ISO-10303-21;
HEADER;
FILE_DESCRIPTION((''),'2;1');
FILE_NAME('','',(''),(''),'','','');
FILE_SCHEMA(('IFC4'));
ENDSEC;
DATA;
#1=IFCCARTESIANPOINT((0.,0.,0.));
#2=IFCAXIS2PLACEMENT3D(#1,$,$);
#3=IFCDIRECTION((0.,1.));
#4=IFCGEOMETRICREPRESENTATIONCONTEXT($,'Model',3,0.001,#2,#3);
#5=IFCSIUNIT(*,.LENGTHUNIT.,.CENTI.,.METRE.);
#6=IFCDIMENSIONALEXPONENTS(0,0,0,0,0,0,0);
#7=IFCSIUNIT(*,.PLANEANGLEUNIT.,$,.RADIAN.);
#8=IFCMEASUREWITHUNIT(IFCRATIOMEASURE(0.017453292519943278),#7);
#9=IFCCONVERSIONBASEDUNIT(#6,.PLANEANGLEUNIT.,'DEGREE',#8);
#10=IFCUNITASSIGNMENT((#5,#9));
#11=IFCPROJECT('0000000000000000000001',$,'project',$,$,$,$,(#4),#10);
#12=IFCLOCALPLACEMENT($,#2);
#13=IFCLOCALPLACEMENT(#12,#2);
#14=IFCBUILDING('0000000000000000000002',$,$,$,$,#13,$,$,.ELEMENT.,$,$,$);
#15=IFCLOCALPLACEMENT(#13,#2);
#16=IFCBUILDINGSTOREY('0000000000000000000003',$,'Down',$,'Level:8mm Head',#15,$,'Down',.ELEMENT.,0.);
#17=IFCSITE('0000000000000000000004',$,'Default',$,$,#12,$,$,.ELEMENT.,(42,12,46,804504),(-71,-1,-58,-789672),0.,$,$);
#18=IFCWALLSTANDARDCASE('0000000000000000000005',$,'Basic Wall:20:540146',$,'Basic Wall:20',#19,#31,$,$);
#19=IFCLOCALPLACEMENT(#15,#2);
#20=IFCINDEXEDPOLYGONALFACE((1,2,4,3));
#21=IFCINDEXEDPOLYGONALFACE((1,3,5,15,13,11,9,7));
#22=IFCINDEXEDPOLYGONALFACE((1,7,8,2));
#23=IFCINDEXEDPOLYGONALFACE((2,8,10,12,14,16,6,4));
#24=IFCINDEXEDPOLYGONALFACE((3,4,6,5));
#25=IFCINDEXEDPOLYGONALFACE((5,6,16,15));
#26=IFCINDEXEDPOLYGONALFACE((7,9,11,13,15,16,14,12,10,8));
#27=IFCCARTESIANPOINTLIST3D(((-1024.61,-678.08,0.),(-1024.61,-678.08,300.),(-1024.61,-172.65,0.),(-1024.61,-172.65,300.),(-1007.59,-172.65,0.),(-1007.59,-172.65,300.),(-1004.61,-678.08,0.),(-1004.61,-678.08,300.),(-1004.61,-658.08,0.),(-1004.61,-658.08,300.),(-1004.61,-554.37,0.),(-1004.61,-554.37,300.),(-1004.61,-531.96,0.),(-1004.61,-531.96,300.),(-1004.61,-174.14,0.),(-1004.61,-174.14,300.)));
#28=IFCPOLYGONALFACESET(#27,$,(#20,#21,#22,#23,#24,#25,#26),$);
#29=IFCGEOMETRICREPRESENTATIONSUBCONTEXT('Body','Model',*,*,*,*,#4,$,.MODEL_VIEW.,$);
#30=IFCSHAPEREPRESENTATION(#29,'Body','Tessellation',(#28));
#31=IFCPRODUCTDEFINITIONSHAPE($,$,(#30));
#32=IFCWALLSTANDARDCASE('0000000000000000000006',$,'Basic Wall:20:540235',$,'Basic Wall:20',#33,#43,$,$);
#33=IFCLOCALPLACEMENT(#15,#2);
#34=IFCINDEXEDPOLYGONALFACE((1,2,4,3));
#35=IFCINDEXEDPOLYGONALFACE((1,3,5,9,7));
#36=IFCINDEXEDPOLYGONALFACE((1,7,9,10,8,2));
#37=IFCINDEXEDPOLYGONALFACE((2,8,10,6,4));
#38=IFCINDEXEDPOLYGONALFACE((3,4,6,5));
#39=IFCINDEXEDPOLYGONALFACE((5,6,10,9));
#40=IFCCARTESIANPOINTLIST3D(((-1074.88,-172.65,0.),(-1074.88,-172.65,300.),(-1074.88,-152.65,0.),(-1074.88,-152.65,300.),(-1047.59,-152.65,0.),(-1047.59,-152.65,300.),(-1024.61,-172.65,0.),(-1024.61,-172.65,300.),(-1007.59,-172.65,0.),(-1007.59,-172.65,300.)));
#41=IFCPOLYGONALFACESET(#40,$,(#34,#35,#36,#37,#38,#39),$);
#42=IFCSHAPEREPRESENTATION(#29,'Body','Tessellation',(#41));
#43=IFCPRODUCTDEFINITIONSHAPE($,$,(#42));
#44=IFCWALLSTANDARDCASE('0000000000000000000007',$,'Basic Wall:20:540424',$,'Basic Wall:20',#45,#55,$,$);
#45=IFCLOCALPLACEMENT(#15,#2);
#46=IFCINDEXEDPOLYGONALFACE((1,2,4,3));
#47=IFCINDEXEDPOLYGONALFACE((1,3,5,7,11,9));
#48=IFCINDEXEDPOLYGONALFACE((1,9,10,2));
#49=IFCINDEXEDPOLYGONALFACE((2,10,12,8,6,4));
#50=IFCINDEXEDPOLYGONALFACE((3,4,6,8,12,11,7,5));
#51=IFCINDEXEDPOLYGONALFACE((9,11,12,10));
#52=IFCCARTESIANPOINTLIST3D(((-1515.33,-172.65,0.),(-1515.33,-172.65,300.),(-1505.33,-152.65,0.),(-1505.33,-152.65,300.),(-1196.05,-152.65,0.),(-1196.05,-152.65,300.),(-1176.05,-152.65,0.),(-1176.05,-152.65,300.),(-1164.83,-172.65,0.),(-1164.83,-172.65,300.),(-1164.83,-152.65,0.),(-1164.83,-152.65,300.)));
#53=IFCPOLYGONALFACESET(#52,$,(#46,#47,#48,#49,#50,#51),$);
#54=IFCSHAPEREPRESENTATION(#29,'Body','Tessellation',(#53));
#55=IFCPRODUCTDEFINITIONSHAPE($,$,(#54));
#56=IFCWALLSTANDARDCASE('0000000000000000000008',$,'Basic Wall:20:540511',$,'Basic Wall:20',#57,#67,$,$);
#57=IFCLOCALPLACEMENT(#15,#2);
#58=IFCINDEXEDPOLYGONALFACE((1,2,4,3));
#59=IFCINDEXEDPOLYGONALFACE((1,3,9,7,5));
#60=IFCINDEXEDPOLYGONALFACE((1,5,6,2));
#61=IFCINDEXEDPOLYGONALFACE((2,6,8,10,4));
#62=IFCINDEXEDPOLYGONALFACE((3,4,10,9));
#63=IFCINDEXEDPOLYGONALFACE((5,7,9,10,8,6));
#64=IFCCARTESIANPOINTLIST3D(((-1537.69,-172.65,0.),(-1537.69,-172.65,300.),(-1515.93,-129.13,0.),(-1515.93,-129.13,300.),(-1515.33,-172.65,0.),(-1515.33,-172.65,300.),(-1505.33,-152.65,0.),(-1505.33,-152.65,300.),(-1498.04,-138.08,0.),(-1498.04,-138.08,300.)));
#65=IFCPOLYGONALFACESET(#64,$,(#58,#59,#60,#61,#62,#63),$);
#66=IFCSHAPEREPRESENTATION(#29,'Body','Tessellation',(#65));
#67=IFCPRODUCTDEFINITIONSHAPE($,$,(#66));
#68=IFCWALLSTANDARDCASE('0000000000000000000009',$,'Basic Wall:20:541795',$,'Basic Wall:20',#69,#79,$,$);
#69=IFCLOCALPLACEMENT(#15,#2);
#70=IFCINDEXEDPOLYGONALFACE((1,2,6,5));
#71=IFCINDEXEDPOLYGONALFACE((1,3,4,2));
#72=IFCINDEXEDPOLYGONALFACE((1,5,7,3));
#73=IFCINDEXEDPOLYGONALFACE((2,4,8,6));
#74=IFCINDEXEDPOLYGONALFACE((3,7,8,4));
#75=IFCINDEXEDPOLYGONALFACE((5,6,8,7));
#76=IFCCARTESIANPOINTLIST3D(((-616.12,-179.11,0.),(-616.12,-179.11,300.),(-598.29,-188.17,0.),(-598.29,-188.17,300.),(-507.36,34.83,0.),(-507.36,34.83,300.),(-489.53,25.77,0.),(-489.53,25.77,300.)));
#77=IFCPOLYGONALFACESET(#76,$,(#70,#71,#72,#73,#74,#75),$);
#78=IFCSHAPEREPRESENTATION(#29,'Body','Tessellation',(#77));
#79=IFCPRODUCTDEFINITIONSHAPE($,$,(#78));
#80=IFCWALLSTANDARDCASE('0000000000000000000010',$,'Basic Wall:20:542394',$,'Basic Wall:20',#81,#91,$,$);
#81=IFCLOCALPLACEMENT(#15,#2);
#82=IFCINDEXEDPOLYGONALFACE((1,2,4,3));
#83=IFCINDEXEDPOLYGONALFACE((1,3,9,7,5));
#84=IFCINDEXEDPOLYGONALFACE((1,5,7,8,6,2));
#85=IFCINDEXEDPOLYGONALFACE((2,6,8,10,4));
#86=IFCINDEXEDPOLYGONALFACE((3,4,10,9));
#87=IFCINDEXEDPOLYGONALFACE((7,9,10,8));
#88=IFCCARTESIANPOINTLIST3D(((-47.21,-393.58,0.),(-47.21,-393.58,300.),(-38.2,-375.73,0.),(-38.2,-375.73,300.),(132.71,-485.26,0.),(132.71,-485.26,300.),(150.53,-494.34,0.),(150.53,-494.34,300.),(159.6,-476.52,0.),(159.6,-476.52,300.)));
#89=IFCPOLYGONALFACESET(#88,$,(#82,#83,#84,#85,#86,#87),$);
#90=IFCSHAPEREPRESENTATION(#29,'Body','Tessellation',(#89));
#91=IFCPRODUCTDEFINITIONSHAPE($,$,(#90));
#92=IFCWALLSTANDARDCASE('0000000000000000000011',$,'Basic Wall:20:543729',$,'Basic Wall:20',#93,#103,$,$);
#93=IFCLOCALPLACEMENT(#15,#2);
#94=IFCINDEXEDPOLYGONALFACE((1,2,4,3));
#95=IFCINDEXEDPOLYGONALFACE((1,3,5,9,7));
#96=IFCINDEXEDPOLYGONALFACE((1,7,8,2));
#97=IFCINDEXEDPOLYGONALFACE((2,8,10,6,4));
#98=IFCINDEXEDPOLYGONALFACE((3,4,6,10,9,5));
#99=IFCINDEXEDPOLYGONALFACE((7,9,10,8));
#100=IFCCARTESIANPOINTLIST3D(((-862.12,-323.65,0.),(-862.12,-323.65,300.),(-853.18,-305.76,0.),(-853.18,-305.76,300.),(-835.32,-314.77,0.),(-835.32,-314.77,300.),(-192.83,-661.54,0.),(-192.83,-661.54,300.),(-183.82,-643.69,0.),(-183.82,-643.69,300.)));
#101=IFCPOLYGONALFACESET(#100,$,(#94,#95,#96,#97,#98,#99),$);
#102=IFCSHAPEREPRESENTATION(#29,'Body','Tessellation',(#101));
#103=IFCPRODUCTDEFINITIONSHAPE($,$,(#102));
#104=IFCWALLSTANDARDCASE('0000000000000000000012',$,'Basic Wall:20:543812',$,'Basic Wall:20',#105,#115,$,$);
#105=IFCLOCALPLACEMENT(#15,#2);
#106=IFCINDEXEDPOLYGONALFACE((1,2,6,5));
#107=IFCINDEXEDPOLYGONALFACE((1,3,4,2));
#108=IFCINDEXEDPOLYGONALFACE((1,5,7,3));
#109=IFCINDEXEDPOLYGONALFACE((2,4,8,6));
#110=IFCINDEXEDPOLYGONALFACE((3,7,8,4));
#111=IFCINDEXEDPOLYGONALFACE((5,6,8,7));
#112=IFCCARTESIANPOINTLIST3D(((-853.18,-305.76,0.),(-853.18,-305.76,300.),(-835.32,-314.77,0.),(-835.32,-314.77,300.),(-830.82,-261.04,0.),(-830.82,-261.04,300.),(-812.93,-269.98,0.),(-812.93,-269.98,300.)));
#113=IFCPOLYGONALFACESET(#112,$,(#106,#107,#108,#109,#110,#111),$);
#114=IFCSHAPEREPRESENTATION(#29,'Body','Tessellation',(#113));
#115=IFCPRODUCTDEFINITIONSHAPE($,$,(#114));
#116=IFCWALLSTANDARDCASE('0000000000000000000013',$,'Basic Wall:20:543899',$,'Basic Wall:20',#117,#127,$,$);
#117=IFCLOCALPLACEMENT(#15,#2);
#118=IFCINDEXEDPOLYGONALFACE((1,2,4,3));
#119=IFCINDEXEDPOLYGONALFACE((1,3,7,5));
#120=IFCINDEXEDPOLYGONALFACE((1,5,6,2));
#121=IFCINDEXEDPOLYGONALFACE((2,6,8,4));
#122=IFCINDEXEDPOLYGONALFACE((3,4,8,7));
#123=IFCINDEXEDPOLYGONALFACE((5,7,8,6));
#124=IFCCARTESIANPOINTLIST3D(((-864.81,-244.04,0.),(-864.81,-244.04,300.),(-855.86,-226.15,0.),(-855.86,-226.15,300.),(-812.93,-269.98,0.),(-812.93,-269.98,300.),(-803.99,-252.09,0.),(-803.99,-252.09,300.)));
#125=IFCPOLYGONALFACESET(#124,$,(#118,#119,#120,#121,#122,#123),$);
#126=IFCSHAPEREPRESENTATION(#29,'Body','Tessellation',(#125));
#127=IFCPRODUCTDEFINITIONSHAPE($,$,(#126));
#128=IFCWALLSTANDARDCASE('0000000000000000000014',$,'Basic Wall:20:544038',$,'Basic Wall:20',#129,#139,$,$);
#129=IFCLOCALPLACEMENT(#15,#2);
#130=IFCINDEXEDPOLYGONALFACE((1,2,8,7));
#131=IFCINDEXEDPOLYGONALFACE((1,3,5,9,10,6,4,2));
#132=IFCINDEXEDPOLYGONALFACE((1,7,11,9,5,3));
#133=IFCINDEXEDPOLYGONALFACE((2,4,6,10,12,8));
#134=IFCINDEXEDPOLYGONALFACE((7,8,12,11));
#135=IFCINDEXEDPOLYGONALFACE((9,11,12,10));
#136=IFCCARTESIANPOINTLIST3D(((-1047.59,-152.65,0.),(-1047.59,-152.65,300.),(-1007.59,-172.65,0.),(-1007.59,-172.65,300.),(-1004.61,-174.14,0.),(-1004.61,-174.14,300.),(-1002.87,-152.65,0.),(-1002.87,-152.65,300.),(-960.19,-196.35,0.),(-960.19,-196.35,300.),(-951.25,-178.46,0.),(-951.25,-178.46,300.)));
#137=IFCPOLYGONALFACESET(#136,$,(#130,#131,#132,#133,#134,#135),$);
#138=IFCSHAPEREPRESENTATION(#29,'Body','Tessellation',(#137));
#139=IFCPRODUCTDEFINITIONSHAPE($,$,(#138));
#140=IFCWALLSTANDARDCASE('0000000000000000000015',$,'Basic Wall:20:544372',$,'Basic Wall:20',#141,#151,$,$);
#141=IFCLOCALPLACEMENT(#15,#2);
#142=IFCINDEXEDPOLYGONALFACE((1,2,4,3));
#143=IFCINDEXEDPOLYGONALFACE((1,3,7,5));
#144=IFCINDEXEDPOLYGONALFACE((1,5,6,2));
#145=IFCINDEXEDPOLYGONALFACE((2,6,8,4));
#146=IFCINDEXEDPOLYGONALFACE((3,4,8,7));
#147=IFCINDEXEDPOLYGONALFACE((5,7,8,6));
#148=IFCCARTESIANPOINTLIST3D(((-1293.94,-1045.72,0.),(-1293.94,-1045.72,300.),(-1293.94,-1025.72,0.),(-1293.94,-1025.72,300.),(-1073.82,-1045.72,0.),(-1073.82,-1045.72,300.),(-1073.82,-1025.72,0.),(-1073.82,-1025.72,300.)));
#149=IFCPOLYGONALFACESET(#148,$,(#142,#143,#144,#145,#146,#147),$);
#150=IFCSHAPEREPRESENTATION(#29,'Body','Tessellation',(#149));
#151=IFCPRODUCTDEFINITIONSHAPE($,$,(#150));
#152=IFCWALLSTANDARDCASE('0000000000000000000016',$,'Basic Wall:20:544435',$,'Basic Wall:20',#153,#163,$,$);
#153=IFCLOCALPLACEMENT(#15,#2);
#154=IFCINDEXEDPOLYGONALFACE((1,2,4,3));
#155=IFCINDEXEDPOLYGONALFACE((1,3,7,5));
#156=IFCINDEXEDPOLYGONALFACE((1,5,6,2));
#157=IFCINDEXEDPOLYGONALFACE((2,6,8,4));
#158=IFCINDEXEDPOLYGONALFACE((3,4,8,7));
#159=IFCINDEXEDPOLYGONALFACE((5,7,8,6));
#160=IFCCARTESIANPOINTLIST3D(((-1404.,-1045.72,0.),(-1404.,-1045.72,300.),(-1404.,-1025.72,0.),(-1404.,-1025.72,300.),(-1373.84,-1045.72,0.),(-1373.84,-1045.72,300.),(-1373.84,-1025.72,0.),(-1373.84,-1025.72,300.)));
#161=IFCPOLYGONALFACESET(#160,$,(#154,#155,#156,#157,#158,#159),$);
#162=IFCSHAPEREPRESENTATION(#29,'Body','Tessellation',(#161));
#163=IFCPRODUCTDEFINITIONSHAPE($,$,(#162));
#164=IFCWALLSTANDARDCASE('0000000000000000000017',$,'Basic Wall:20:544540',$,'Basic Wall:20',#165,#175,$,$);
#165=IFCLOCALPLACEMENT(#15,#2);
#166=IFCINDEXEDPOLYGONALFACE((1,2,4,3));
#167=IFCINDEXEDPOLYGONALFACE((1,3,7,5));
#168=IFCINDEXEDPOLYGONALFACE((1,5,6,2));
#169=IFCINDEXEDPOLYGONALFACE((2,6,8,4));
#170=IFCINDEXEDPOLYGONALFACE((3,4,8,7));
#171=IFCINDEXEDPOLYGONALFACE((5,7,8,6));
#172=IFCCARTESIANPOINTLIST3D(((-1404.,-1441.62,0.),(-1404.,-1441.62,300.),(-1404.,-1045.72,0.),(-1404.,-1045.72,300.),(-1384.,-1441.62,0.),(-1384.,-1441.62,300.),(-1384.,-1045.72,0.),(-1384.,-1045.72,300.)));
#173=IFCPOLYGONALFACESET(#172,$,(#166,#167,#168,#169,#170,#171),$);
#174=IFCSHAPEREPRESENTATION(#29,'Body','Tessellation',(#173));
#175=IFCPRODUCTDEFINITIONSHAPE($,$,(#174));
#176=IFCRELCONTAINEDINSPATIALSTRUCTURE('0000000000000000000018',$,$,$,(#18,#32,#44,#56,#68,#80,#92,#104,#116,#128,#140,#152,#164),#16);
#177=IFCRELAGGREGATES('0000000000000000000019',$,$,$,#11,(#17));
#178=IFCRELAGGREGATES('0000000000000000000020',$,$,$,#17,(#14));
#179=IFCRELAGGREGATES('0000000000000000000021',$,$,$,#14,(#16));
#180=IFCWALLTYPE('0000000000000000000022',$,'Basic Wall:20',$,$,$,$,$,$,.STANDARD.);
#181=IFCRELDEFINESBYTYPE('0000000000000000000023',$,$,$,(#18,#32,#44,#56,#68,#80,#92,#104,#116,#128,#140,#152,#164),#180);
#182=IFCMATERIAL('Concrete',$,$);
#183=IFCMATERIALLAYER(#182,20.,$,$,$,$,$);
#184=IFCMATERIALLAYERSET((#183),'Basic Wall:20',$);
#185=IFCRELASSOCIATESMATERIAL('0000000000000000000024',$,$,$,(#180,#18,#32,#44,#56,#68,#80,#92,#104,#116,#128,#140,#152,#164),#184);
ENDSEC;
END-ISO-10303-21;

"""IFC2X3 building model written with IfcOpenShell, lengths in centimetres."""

from ifc_helpers import new_model, entity, si_unit, converted_unit, direction, frame, frame_2d, origin, place, context, subcontext, project, spatial, polyline, rectangle, outline, extrude, material, layer, layer_set, layer_usage, type_object, element, save


model = new_model("IFC2X3")

# Units and contexts
model_context = context("Model", 3, precision=0.001, world=origin(), true_north=direction((0.0, 1.0)))
body_context = subcontext(model_context, "Body", "Model", "MODEL_VIEW")
ifc_project = project(units=[si_unit("LENGTHUNIT", "METRE", prefix="CENTI"), converted_unit("PLANEANGLEUNIT", "DEGREE", entity("IfcRatioMeasure", 0.017453292519943278), si_unit("PLANEANGLEUNIT", "RADIAN"), dimensions=[0, 0, 0, 0, 0, 0, 0])], contexts=[model_context])

# Site, building, storey
site_placement = place(None, origin())
site = spatial("IfcSite", under=ifc_project, at=site_placement, Name="Default", CompositionType="ELEMENT", RefLatitude=(42, 12, 46, 804504), RefLongitude=(-71, -1, -58, -789672), RefElevation=0.0)
building_placement = place(site_placement, origin())
building = spatial("IfcBuilding", under=site, at=building_placement, CompositionType="ELEMENT")
storey_placement = place(building_placement, origin())
storey = spatial("IfcBuildingStorey", under=building, at=storey_placement, Name="Down", ObjectType="Level:8mm Head", LongName="Down", CompositionType="ELEMENT", Elevation=0.0)

# Walls
ifc_material = material(Name="Concrete")
ifc_layer_1 = layer(ifc_material, 20.0)
ifc_layer_set_1 = layer_set([ifc_layer_1], Name="Basic Wall:20")
ifc_layer_usage_1 = layer_usage(ifc_layer_set_1, "AXIS2", "NEGATIVE", 10.0)
wall_type_1 = type_object("IfcWallType", Name="Basic Wall:20", PredefinedType="STANDARD", material=ifc_layer_set_1)
wall_1_placement = place(storey_placement, frame((-1014.61, -678.08, 0.0), z_axis=(0.0, 0.0, 1.0), x_axis=(0.0, 1.0, 0.0)))
element("IfcWallStandardCase", 1, at=wall_1_placement, inside=storey, type_object=wall_type_1, material=ifc_layer_usage_1, Name="Basic Wall:20:540146", ObjectType="Basic Wall:20", context=body_context, shape_type="SweptSolid", body=[
    extrude(outline(polyline([(503.94, -10.0), (505.43, -7.02), (505.43, 10.0), (0.0, 10.0), (0.0, -10.0), (20.0, -10.0), (123.71, -10.0), (146.12, -10.0), (503.94, -10.0)])), origin(), (0.0, 0.0, 1.0), 300.0),
])
ifc_layer_usage_2 = layer_usage(ifc_layer_set_1, "AXIS2", "POSITIVE", -10.0)
wall_2_placement = place(storey_placement, frame((-1007.59, -162.65, 0.0), z_axis=(0.0, 0.0, 1.0), x_axis=(-1.0, 0.0, 0.0)))
element("IfcWallStandardCase", 2, at=wall_2_placement, inside=storey, type_object=wall_type_1, material=ifc_layer_usage_2, Name="Basic Wall:20:540235", ObjectType="Basic Wall:20", context=body_context, shape_type="SweptSolid", body=[
    extrude(outline(polyline([(67.29, -10.0), (67.29, 10.0), (17.02, 10.0), (0.0, 10.0), (40.0, -10.0), (67.29, -10.0)])), origin(), (0.0, 0.0, 1.0), 300.0),
])
ifc_layer_usage_3 = layer_usage(ifc_layer_set_1, "AXIS2", "POSITIVE", -10.0)
wall_3_placement = place(storey_placement, frame((-1164.83, -162.65, 0.0), z_axis=(0.0, 0.0, 1.0), x_axis=(-1.0, 0.0, 0.0)))
element("IfcWallStandardCase", 3, at=wall_3_placement, inside=storey, type_object=wall_type_1, material=ifc_layer_usage_3, Name="Basic Wall:20:540424", ObjectType="Basic Wall:20", context=body_context, shape_type="SweptSolid", body=[
    extrude(outline(polyline([(340.5, -10.0), (350.5, 10.0), (0.0, 10.0), (0.0, -10.0), (11.22, -10.0), (31.22, -10.0), (340.5, -10.0)])), origin(), (0.0, 0.0, 1.0), 300.0),
])
ifc_layer_usage_4 = layer_usage(ifc_layer_set_1, "AXIS2", "NEGATIVE", 10.0)
wall_4_placement = place(storey_placement, frame((-1528.74, -177.12, 0.0), z_axis=(0.0, 0.0, 1.0), x_axis=(0.447214, 0.894427, 0.0)))
element("IfcWallStandardCase", 4, at=wall_4_placement, inside=storey, type_object=wall_type_1, material=ifc_layer_usage_4, Name="Basic Wall:20:540511", ObjectType="Basic Wall:20", context=body_context, shape_type="SweptSolid", body=[
    extrude(outline(polyline([(48.65, -10.0), (48.65, 10.0), (0.0, 10.0), (10.0, -10.0), (32.36, -10.0), (48.65, -10.0)])), origin(), (0.0, 0.0, 1.0), 300.0),
])
ifc_layer_usage_5 = layer_usage(ifc_layer_set_1, "AXIS2", "NEGATIVE", 10.0)
wall_5_placement = place(storey_placement, frame((-607.2, -183.64, 0.0), z_axis=(0.0, 0.0, 1.0), x_axis=(0.45318, 0.891419, 0.0)))
element("IfcWallStandardCase", 5, at=wall_5_placement, inside=storey, type_object=wall_type_1, material=ifc_layer_usage_5, Name="Basic Wall:20:541795", ObjectType="Basic Wall:20", context=body_context, shape_type="SweptSolid", body=[
    extrude(rectangle(XDim=240.0, YDim=20.0, at=frame_2d((120.0, 0.0), x_axis=(-1.0, 0.0))), origin(), (0.0, 0.0, 1.0), 300.0),
])
ifc_layer_usage_6 = layer_usage(ifc_layer_set_1, "AXIS2", "NEGATIVE", 10.0)
wall_6_placement = place(storey_placement, frame((-42.74, -384.64, 0.0), z_axis=(0.0, 0.0, 1.0), x_axis=(0.890996, -0.454011, 0.0)))
element("IfcWallStandardCase", 6, at=wall_6_placement, inside=storey, type_object=wall_type_1, material=ifc_layer_usage_6, Name="Basic Wall:20:542394", ObjectType="Basic Wall:20", context=body_context, shape_type="SweptSolid", body=[
    extrude(outline(polyline([(222.02, -10.0), (222.0, 10.0), (0.0, 10.0), (0.08, -10.0), (202.02, -10.0), (222.02, -10.0)])), origin(), (0.0, 0.0, 1.0), 300.0),
])
ifc_layer_usage_7 = layer_usage(ifc_layer_set_1, "AXIS2", "POSITIVE", -10.0)
wall_7_placement = place(storey_placement, frame((-188.32, -652.61, 0.0), z_axis=(0.0, 0.0, 1.0), x_axis=(-0.892687, 0.450677, 0.0)))
element("IfcWallStandardCase", 7, at=wall_7_placement, inside=storey, type_object=wall_type_1, material=ifc_layer_usage_7, Name="Basic Wall:20:543729", ObjectType="Basic Wall:20", context=body_context, shape_type="SweptSolid", body=[
    extrude(outline(polyline([(749.83, -10.0), (749.75, 10.0), (0.0, 10.0), (0.0, -10.0), (729.83, -10.0), (749.83, -10.0)])), origin(), (0.0, 0.0, 1.0), 300.0),
])
ifc_layer_usage_8 = layer_usage(ifc_layer_set_1, "AXIS2", "NEGATIVE", 10.0)
wall_8_placement = place(storey_placement, frame((-844.27, -310.3, 0.0), z_axis=(0.0, 0.0, 1.0), x_axis=(0.447214, 0.894427, 0.0)))
element("IfcWallStandardCase", 8, at=wall_8_placement, inside=storey, type_object=wall_type_1, material=ifc_layer_usage_8, Name="Basic Wall:20:543812", ObjectType="Basic Wall:20", context=body_context, shape_type="SweptSolid", body=[
    extrude(outline(polyline([(50.08, -10.0), (50.08, 10.0), (0.08, 10.0), (0.0, -10.0), (50.08, -10.0)])), origin(), (0.0, 0.0, 1.0), 300.0),
])
ifc_layer_usage_9 = layer_usage(ifc_layer_set_1, "AXIS2", "POSITIVE", -10.0)
wall_9_placement = place(storey_placement, frame((-808.46, -261.04, 0.0), z_axis=(0.0, 0.0, 1.0), x_axis=(-0.894427, 0.447214, 0.0)))
element("IfcWallStandardCase", 9, at=wall_9_placement, inside=storey, type_object=wall_type_1, material=ifc_layer_usage_9, Name="Basic Wall:20:543899", ObjectType="Basic Wall:20", context=body_context, shape_type="SweptSolid", body=[
    extrude(rectangle(XDim=58.0, YDim=20.0, at=frame_2d((29.0, 0.0), x_axis=(-1.0, 0.0))), origin(), (0.0, 0.0, 1.0), 300.0),
])
ifc_layer_usage_10 = layer_usage(ifc_layer_set_1, "AXIS2", "POSITIVE", -10.0)
wall_10_placement = place(storey_placement, frame((-955.72, -187.4, 0.0), z_axis=(0.0, 0.0, 1.0), x_axis=(-0.894427, 0.447214, 0.0)))
element("IfcWallStandardCase", 10, at=wall_10_placement, inside=storey, type_object=wall_type_1, material=ifc_layer_usage_10, Name="Basic Wall:20:544038", ObjectType="Basic Wall:20", context=body_context, shape_type="SweptSolid", body=[
    extrude(outline(polyline([(57.71, -10.0), (97.71, 10.0), (52.99, 10.0), (49.66, 10.0), (0.0, 10.0), (0.0, -10.0), (57.71, -10.0)])), origin(), (0.0, 0.0, 1.0), 300.0),
])
ifc_layer_usage_11 = layer_usage(ifc_layer_set_1, "AXIS2", "POSITIVE", -10.0)
wall_11_placement = place(storey_placement, frame((-1073.82, -1035.72, 0.0), z_axis=(0.0, 0.0, 1.0), x_axis=(-1.0, 0.0, 0.0)))
element("IfcWallStandardCase", 11, at=wall_11_placement, inside=storey, type_object=wall_type_1, material=ifc_layer_usage_11, Name="Basic Wall:20:544372", ObjectType="Basic Wall:20", context=body_context, shape_type="SweptSolid", body=[
    extrude(rectangle(XDim=220.12, YDim=20.0, at=frame_2d((110.06, 0.0), x_axis=(-1.0, 0.0))), origin(), (0.0, 0.0, 1.0), 300.0),
])
ifc_layer_usage_12 = layer_usage(ifc_layer_set_1, "AXIS2", "NEGATIVE", 10.0)
wall_12_placement = place(storey_placement, frame((-1373.84, -1035.72, 0.0), z_axis=(0.0, 0.0, 1.0), x_axis=(-1.0, 0.0, 0.0)))
element("IfcWallStandardCase", 12, at=wall_12_placement, inside=storey, type_object=wall_type_1, material=ifc_layer_usage_12, Name="Basic Wall:20:544435", ObjectType="Basic Wall:20", context=body_context, shape_type="SweptSolid", body=[
    extrude(rectangle(XDim=30.16, YDim=20.0, at=frame_2d((15.08, 0.0), x_axis=(-1.0, 0.0))), origin(), (0.0, 0.0, 1.0), 300.0),
])
ifc_layer_usage_13 = layer_usage(ifc_layer_set_1, "AXIS2", "POSITIVE", -10.0)
wall_13_placement = place(storey_placement, frame((-1394.0, -1045.72, 0.0), z_axis=(0.0, 0.0, 1.0), x_axis=(0.0, -1.0, 0.0)))
element("IfcWallStandardCase", 13, at=wall_13_placement, inside=storey, type_object=wall_type_1, material=ifc_layer_usage_13, Name="Basic Wall:20:544540", ObjectType="Basic Wall:20", context=body_context, shape_type="SweptSolid", body=[
    extrude(rectangle(XDim=395.9, YDim=20.0, at=frame_2d((197.95, 0.0), x_axis=(-1.0, 0.0))), origin(), (0.0, 0.0, 1.0), 300.0),
])

save(model, "model.ifc")
